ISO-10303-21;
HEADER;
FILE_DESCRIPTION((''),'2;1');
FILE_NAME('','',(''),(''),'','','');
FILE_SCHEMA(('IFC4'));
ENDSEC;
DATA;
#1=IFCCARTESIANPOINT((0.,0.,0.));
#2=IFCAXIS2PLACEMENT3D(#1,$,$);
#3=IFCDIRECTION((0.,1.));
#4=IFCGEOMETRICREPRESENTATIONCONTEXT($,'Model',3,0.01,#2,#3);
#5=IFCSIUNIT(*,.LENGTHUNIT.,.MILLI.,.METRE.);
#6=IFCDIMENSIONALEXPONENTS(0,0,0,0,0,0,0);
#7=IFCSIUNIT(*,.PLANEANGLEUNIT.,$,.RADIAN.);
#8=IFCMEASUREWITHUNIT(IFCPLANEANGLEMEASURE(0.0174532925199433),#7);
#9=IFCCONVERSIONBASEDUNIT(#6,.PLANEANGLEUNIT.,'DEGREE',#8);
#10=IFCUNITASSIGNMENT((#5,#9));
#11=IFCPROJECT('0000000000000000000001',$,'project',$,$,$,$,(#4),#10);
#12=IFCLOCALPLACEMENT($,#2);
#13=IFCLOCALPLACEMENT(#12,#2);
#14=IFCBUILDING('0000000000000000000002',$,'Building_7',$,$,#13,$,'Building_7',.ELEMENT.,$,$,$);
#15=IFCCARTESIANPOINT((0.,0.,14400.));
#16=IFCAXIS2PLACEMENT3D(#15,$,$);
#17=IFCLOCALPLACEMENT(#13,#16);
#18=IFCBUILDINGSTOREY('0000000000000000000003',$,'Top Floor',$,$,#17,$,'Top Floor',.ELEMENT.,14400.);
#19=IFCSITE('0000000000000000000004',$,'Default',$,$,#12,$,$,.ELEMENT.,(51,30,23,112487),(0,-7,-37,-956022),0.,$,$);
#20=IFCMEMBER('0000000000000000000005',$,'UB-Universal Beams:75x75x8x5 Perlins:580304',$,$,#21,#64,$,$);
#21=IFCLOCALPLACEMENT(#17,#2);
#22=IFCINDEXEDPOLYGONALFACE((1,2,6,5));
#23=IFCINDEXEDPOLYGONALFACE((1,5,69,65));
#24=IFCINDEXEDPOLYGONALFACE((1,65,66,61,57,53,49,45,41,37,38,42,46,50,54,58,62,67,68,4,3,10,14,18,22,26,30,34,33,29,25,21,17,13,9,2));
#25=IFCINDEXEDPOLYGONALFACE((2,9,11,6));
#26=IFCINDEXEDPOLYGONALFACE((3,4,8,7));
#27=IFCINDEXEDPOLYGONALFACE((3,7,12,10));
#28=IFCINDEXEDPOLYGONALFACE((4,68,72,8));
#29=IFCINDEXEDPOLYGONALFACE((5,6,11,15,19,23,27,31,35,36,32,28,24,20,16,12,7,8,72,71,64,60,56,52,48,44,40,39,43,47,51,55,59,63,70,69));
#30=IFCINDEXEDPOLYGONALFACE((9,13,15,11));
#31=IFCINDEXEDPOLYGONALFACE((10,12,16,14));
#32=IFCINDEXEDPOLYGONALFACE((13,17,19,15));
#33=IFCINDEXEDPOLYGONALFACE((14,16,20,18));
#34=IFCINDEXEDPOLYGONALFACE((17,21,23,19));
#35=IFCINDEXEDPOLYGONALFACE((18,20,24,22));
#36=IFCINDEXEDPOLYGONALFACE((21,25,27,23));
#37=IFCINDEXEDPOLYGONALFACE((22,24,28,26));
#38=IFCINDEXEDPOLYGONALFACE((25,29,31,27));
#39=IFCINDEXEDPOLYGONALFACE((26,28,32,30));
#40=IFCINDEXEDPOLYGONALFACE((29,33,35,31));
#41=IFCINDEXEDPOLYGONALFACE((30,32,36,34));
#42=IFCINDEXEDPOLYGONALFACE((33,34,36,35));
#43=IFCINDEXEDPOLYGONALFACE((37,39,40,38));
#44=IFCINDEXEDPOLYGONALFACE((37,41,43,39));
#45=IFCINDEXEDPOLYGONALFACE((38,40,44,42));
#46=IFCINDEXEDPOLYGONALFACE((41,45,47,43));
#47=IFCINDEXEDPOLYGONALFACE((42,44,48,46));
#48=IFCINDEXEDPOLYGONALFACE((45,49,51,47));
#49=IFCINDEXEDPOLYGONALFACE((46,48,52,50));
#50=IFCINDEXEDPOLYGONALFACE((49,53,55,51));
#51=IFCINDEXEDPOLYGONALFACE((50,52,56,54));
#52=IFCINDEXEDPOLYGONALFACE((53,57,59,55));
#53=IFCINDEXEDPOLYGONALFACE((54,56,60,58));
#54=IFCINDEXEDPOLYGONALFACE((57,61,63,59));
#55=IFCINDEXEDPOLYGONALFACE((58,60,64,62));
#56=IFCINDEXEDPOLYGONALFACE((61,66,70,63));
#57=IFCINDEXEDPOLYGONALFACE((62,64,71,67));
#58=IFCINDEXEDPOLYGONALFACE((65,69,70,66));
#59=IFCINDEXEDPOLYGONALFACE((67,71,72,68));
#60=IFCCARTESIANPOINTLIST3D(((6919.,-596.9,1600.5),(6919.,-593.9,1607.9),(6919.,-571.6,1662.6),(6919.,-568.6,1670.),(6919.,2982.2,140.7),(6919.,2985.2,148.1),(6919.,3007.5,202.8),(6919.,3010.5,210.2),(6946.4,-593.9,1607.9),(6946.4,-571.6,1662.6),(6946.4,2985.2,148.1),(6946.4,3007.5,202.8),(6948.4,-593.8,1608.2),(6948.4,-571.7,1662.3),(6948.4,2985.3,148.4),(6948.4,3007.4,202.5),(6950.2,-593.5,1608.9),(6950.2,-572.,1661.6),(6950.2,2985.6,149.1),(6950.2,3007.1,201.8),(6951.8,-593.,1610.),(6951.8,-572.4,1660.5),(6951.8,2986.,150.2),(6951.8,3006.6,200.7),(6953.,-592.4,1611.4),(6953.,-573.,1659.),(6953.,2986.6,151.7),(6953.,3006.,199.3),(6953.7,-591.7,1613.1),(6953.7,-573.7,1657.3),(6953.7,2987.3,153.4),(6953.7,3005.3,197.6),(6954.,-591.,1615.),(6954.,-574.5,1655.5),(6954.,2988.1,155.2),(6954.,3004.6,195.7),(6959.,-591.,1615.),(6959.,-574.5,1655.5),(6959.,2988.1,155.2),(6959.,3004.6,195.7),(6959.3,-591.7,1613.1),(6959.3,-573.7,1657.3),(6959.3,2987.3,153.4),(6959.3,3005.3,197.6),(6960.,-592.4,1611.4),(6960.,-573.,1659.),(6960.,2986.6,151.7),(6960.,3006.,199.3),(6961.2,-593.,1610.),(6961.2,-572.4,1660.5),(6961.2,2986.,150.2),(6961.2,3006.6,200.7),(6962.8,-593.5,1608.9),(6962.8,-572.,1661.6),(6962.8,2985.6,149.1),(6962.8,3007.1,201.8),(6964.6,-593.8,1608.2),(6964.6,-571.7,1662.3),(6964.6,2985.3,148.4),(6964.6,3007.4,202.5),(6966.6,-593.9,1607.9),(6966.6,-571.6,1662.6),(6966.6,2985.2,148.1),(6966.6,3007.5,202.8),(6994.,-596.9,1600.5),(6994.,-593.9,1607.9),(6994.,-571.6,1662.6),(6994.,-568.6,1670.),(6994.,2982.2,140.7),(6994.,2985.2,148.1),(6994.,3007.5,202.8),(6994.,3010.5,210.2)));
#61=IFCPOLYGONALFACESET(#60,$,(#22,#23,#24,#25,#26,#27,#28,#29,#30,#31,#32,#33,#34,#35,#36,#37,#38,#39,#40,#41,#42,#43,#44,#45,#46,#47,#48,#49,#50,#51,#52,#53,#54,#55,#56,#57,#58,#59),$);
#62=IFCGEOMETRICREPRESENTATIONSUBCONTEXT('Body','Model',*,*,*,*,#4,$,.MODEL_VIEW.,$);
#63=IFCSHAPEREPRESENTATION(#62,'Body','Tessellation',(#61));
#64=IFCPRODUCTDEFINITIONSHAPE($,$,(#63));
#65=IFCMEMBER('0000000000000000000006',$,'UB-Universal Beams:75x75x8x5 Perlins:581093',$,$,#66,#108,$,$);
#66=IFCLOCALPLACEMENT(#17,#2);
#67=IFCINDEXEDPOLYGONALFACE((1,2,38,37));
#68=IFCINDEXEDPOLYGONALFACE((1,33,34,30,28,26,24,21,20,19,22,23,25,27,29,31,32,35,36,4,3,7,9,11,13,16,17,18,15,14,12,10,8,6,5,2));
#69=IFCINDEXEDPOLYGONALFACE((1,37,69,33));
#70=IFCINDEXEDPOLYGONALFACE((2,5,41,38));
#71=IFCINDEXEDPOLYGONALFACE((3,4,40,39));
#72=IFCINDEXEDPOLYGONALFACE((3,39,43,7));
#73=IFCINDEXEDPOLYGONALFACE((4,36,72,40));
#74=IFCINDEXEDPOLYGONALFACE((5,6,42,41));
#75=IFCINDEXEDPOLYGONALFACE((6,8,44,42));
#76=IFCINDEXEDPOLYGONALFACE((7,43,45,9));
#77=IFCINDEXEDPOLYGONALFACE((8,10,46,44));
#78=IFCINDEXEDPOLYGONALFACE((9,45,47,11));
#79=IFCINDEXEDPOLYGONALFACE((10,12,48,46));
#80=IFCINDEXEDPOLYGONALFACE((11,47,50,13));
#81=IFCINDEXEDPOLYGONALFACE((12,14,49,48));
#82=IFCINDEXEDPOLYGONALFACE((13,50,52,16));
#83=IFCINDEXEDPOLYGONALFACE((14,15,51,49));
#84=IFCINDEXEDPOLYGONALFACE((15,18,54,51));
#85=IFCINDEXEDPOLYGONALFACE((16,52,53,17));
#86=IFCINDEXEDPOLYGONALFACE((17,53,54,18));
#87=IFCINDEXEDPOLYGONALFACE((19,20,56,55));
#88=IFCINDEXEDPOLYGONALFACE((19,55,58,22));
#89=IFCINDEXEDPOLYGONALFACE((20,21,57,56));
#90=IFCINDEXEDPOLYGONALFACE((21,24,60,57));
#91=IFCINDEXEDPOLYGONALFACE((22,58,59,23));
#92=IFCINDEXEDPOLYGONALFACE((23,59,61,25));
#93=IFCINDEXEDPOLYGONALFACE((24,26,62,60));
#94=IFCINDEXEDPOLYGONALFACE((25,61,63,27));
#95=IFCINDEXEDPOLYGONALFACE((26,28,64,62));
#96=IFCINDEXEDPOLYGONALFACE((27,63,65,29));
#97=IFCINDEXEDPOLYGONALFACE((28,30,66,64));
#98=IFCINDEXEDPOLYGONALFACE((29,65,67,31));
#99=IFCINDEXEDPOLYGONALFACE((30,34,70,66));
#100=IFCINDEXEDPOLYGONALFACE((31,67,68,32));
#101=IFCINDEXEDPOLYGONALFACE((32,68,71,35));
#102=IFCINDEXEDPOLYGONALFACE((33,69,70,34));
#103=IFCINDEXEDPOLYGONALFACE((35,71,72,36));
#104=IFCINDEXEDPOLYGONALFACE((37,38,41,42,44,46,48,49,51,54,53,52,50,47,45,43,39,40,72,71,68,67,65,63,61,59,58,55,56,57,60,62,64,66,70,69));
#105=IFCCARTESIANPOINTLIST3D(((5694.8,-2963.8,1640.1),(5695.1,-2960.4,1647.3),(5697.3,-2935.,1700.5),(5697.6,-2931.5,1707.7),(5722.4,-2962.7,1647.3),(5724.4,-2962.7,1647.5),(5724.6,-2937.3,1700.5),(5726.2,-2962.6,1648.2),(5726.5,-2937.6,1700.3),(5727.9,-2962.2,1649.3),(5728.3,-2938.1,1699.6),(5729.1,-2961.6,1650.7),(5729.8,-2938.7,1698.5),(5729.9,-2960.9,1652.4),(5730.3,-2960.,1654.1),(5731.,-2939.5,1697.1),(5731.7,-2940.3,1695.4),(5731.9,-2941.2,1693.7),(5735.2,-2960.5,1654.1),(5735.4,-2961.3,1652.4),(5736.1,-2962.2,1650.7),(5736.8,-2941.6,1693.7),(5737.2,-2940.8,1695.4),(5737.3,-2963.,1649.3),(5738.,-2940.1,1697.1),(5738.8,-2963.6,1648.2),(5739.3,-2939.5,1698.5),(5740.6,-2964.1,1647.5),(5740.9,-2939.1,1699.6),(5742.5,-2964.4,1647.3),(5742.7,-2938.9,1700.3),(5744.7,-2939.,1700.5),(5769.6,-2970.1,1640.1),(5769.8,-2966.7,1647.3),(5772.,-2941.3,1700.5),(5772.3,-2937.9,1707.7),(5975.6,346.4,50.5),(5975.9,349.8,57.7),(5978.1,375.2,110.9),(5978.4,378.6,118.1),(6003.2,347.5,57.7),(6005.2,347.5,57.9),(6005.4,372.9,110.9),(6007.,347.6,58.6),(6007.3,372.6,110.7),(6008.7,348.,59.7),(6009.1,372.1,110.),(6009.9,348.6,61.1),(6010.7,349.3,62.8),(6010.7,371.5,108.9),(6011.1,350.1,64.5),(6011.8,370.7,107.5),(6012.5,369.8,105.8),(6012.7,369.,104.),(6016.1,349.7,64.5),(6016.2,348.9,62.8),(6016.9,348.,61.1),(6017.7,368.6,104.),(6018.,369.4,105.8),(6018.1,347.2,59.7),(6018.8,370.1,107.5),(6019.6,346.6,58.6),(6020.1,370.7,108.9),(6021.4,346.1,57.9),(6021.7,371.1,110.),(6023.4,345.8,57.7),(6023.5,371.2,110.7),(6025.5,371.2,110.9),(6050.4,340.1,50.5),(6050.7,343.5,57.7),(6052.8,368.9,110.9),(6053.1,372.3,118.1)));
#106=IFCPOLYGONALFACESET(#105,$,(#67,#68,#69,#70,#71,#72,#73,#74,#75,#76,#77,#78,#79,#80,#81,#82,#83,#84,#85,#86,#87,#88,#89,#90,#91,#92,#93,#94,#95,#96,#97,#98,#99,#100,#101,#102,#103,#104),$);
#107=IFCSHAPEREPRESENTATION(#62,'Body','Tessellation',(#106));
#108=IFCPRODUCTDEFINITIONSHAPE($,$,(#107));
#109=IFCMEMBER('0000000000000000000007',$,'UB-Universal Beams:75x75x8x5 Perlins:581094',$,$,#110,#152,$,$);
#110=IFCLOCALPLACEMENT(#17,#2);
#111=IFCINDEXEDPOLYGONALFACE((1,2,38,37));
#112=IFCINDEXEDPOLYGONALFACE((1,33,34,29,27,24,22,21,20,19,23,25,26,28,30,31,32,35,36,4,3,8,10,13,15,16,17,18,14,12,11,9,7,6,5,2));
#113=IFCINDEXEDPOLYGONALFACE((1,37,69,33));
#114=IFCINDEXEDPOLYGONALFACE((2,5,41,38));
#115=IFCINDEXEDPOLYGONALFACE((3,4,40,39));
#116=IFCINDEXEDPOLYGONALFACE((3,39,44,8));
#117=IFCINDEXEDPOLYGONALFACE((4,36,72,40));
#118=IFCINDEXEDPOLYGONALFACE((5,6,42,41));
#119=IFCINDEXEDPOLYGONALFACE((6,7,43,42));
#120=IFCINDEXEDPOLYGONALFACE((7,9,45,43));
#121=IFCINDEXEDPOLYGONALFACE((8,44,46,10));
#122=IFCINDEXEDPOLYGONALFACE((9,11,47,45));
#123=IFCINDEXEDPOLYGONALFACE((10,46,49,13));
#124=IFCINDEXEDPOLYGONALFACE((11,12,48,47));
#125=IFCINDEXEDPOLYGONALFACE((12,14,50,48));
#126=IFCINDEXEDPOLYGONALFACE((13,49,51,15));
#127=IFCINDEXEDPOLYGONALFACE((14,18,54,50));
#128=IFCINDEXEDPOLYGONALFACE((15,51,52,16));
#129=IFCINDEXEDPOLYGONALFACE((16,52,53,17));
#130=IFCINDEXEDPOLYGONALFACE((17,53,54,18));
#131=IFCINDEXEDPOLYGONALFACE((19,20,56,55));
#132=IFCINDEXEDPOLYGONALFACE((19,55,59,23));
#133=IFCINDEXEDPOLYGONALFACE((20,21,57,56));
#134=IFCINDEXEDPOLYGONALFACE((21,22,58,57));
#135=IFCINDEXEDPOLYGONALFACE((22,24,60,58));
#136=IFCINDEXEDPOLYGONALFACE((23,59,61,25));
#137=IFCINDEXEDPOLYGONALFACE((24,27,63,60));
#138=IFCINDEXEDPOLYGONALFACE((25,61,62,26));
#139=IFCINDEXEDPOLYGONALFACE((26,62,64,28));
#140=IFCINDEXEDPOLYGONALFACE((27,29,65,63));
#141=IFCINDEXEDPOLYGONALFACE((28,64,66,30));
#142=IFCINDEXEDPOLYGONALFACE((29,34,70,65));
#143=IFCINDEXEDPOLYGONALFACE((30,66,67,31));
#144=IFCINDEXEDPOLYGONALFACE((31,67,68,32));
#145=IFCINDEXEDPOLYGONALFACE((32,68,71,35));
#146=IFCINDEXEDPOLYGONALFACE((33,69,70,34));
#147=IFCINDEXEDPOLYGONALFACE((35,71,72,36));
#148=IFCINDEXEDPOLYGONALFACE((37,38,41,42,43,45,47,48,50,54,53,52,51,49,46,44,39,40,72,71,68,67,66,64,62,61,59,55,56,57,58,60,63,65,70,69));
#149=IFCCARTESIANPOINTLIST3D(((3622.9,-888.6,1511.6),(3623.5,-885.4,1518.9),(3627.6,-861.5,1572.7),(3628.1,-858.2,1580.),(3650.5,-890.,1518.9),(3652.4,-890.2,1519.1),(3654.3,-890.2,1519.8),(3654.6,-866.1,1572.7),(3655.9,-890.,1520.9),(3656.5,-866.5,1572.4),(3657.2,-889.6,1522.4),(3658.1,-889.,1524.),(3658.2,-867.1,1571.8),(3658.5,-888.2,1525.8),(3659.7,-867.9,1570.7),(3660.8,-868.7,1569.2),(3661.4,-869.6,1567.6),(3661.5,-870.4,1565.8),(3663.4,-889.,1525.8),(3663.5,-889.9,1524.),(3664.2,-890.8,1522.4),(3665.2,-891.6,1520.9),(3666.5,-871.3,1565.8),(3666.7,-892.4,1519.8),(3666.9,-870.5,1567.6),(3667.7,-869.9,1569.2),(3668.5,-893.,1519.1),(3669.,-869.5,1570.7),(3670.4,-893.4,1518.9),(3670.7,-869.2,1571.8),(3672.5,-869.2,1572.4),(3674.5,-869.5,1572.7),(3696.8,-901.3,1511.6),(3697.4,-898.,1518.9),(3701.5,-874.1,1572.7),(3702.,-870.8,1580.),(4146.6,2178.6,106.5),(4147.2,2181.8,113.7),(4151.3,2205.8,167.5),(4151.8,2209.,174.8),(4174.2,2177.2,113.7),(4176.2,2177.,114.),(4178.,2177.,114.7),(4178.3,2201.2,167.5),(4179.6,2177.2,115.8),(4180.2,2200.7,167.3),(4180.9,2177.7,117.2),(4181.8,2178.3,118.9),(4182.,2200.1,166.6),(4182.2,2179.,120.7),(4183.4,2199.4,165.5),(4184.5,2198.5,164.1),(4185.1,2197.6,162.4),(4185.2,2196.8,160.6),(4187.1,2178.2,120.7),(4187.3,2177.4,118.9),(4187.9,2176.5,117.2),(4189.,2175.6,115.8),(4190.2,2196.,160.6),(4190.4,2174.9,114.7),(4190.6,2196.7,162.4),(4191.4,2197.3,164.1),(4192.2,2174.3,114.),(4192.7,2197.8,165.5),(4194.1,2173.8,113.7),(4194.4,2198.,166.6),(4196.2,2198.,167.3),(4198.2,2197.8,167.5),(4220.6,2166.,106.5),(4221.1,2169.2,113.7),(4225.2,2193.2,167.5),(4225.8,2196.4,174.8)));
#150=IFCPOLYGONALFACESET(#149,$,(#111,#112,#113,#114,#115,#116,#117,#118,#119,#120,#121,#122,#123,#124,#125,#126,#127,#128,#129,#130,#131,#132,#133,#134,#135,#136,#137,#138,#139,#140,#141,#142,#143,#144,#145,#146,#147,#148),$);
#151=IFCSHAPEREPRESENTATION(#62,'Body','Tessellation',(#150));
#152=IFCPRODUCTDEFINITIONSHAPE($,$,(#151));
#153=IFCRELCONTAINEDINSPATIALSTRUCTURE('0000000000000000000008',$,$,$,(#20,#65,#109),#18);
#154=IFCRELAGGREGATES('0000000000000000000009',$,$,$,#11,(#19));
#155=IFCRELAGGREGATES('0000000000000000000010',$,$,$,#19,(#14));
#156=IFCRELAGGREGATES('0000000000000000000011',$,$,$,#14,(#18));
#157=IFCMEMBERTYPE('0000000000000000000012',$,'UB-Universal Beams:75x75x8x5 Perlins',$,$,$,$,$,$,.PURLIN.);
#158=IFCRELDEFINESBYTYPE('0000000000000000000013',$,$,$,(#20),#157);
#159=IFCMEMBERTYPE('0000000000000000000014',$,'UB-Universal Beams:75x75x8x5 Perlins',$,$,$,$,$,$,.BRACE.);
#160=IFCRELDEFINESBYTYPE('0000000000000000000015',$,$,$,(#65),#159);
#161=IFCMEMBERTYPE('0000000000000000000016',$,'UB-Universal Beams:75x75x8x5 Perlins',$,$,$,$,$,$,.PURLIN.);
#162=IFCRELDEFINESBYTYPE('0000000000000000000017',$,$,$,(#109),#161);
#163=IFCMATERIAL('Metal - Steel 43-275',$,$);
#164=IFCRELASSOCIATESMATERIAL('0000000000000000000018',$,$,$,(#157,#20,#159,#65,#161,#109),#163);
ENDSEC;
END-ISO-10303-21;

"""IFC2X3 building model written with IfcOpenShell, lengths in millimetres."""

from ifc_helpers import new_model, entity, si_unit, converted_unit, direction, frame, frame_2d, origin, place, context, subcontext, project, spatial, polyline, circle_curve, parameter, trimmed, segment, composite_curve, outline, extrude, source, transform, mapped, material, type_object, type_shapes, element, save


model = new_model("IFC2X3")

# Units and contexts
model_context = context("Model", 3, precision=0.01, world=origin(), true_north=direction((0.0, 1.0)))
body_context = subcontext(model_context, "Body", "Model", "MODEL_VIEW")
ifc_project = project(units=[si_unit("LENGTHUNIT", "METRE", prefix="MILLI"), converted_unit("PLANEANGLEUNIT", "DEGREE", entity("IfcPlaneAngleMeasure", 0.0174532925199433), si_unit("PLANEANGLEUNIT", "RADIAN"), dimensions=[0, 0, 0, 0, 0, 0, 0])], contexts=[model_context])

# Site, building, storey
site_placement = place(None, origin())
site = spatial("IfcSite", under=ifc_project, at=site_placement, Name="Default", CompositionType="ELEMENT", RefLatitude=(51, 30, 23, 112487), RefLongitude=(0, -7, -37, -956022), RefElevation=0.0)
building_placement = place(site_placement, origin())
building = spatial("IfcBuilding", under=site, at=building_placement, Name="Building_7", LongName="Building_7", CompositionType="ELEMENT")
storey_placement = place(building_placement, frame((0.0, 0.0, 14400.0)))
storey = spatial("IfcBuildingStorey", under=building, at=storey_placement, Name="Top Floor", LongName="Top Floor", CompositionType="ELEMENT", Elevation=14400.0)

# Shared definitions
ifc_material = material(Name="Metal - Steel 43-275")

# Members
member_type_1 = type_object("IfcMemberType", Name="UB-Universal Beams:75x75x8x5 Perlins", PredefinedType="PURLIN", material=ifc_material)
shared_shape_1 = source(origin(), body_context, "Body", "SweptSolid", [
    extrude(outline(composite_curve([segment(polyline([(29.5, -37.5), (37.5, -37.5)]), True, "CONTINUOUS"), segment(polyline([(37.5, -37.5), (37.5, 37.5)]), True, "CONTINUOUS"), segment(polyline([(37.5, 37.5), (29.5, 37.5)]), True, "CONTINUOUS"), segment(polyline([(29.5, 37.5), (29.5, 10.1)]), True, "CONTINUOUS"), segment(trimmed(circle_curve(frame_2d((21.9, 10.1), x_axis=(0.0, 1.0)), 7.6), [parameter(180.0)], [parameter(270.0)], True, "PARAMETER"), False, "CONTINUOUS"), segment(polyline([(21.9, 2.5), (-21.9, 2.5)]), True, "CONTINUOUS"), segment(trimmed(circle_curve(frame_2d((-21.9, 10.1), x_axis=(0.0, 1.0)), 7.6), [parameter(90.0)], [parameter(180.0)], True, "PARAMETER"), False, "CONTINUOUS"), segment(polyline([(-29.5, 10.1), (-29.5, 37.5)]), True, "CONTINUOUS"), segment(polyline([(-29.5, 37.5), (-37.5, 37.5)]), True, "CONTINUOUS"), segment(polyline([(-37.5, 37.5), (-37.5, -37.5)]), True, "CONTINUOUS"), segment(polyline([(-37.5, -37.5), (-29.5, -37.5)]), True, "CONTINUOUS"), segment(polyline([(-29.5, -37.5), (-29.5, -10.1)]), True, "CONTINUOUS"), segment(trimmed(circle_curve(frame_2d((-21.9, -10.1), x_axis=(0.0, 1.0)), 7.6), [parameter(360.0)], [parameter(90.0)], True, "PARAMETER"), False, "CONTINUOUS"), segment(polyline([(-21.9, -2.5), (21.9, -2.5)]), True, "CONTINUOUS"), segment(trimmed(circle_curve(frame_2d((21.9, -10.1), x_axis=(0.0, 1.0)), 7.6), [parameter(270.0)], [parameter(360.0)], True, "PARAMETER"), False, "CONTINUOUS"), segment(polyline([(29.5, -10.1), (29.5, -37.5)]), True, "CONTINUOUS")], self_intersect=False)), frame((-1965.2, 0.0, 0.0), z_axis=(1.0, 0.0, 0.0), x_axis=(0.0, 0.0, -1.0)), (0.0, 0.0, 1.0), 3865.3),
])
type_shapes(member_type_1, [shared_shape_1])
member_1_placement = place(storey_placement, frame((6956.5, 1176.7, 917.6), z_axis=(0.0, 0.377661, 0.925944), x_axis=(0.0, -0.925944, 0.377661)))
element("IfcMember", 1, at=member_1_placement, inside=storey, type_object=member_type_1, material=ifc_material, Name="UB-Universal Beams:75x75x8x5 Perlins:580304", context=body_context, shape_type="MappedRepresentation", body=[
    mapped(shared_shape_1, transform((0.0, 0.0, 0.0), scale=1.0)),
])
member_type_2 = type_object("IfcMemberType", Name="UB-Universal Beams:75x75x8x5 Perlins", PredefinedType="BRACE", material=ifc_material)
shared_shape_2 = source(origin(), body_context, "Body", "SweptSolid", [
    extrude(outline(composite_curve([segment(polyline([(29.5, -37.5), (37.5, -37.5)]), True, "CONTINUOUS"), segment(polyline([(37.5, -37.5), (37.5, 37.5)]), True, "CONTINUOUS"), segment(polyline([(37.5, 37.5), (29.5, 37.5)]), True, "CONTINUOUS"), segment(polyline([(29.5, 37.5), (29.5, 10.1)]), True, "CONTINUOUS"), segment(trimmed(circle_curve(frame_2d((21.9, 10.1), x_axis=(0.0, 1.0)), 7.6), [parameter(180.0)], [parameter(270.0)], True, "PARAMETER"), False, "CONTINUOUS"), segment(polyline([(21.9, 2.5), (-21.9, 2.5)]), True, "CONTINUOUS"), segment(trimmed(circle_curve(frame_2d((-21.9, 10.1), x_axis=(0.0, 1.0)), 7.6), [parameter(90.0)], [parameter(180.0)], True, "PARAMETER"), False, "CONTINUOUS"), segment(polyline([(-29.5, 10.1), (-29.5, 37.5)]), True, "CONTINUOUS"), segment(polyline([(-29.5, 37.5), (-37.5, 37.5)]), True, "CONTINUOUS"), segment(polyline([(-37.5, 37.5), (-37.5, -37.5)]), True, "CONTINUOUS"), segment(polyline([(-37.5, -37.5), (-29.5, -37.5)]), True, "CONTINUOUS"), segment(polyline([(-29.5, -37.5), (-29.5, -10.1)]), True, "CONTINUOUS"), segment(trimmed(circle_curve(frame_2d((-21.9, -10.1), x_axis=(0.0, 1.0)), 7.6), [parameter(360.0)], [parameter(90.0)], True, "PARAMETER"), False, "CONTINUOUS"), segment(polyline([(-21.9, -2.5), (21.9, -2.5)]), True, "CONTINUOUS"), segment(trimmed(circle_curve(frame_2d((21.9, -10.1), x_axis=(0.0, 1.0)), 7.6), [parameter(270.0)], [parameter(360.0)], True, "PARAMETER"), False, "CONTINUOUS"), segment(polyline([(29.5, -10.1), (29.5, -37.5)]), True, "CONTINUOUS")], self_intersect=False)), frame((-1841.4, 0.0, 0.0), z_axis=(1.0, 0.0, 0.0), x_axis=(0.0, 0.0, -1.0)), (0.0, 0.0, 1.0), 3682.8),
])
type_shapes(member_type_2, [shared_shape_2])
member_2_placement = place(storey_placement, frame((5874.0, -1295.7, 879.1), z_axis=(0.036485, 0.430084, 0.902052), x_axis=(-0.076249, -0.898823, 0.431628)))
element("IfcMember", 2, at=member_2_placement, inside=storey, type_object=member_type_2, material=ifc_material, Name="UB-Universal Beams:75x75x8x5 Perlins:581093", context=body_context, shape_type="MappedRepresentation", body=[
    mapped(shared_shape_2, transform((0.0, 0.0, 0.0), scale=1.0)),
])
member_type_3 = type_object("IfcMemberType", Name="UB-Universal Beams:75x75x8x5 Perlins", PredefinedType="PURLIN", material=ifc_material)
shared_shape_3 = source(origin(), body_context, "Body", "SweptSolid", [
    extrude(outline(composite_curve([segment(polyline([(29.5, -37.5), (37.5, -37.5)]), True, "CONTINUOUS"), segment(polyline([(37.5, -37.5), (37.5, 37.5)]), True, "CONTINUOUS"), segment(polyline([(37.5, 37.5), (29.5, 37.5)]), True, "CONTINUOUS"), segment(polyline([(29.5, 37.5), (29.5, 10.1)]), True, "CONTINUOUS"), segment(trimmed(circle_curve(frame_2d((21.9, 10.1), x_axis=(0.0, 1.0)), 7.6), [parameter(180.0)], [parameter(270.0)], True, "PARAMETER"), False, "CONTINUOUS"), segment(polyline([(21.9, 2.5), (-21.9, 2.5)]), True, "CONTINUOUS"), segment(trimmed(circle_curve(frame_2d((-21.9, 10.1), x_axis=(0.0, 1.0)), 7.6), [parameter(90.0)], [parameter(180.0)], True, "PARAMETER"), False, "CONTINUOUS"), segment(polyline([(-29.5, 10.1), (-29.5, 37.5)]), True, "CONTINUOUS"), segment(polyline([(-29.5, 37.5), (-37.5, 37.5)]), True, "CONTINUOUS"), segment(polyline([(-37.5, 37.5), (-37.5, -37.5)]), True, "CONTINUOUS"), segment(polyline([(-37.5, -37.5), (-29.5, -37.5)]), True, "CONTINUOUS"), segment(polyline([(-29.5, -37.5), (-29.5, -10.1)]), True, "CONTINUOUS"), segment(trimmed(circle_curve(frame_2d((-21.9, -10.1), x_axis=(0.0, 1.0)), 7.6), [parameter(360.0)], [parameter(90.0)], True, "PARAMETER"), False, "CONTINUOUS"), segment(polyline([(-21.9, -2.5), (21.9, -2.5)]), True, "CONTINUOUS"), segment(trimmed(circle_curve(frame_2d((21.9, -10.1), x_axis=(0.0, 1.0)), 7.6), [parameter(270.0)], [parameter(360.0)], True, "PARAMETER"), False, "CONTINUOUS"), segment(polyline([(29.5, -10.1), (29.5, -37.5)]), True, "CONTINUOUS")], self_intersect=False)), frame((-1707.1, 0.0, 0.0), z_axis=(1.0, 0.0, 0.0), x_axis=(0.0, 0.0, -1.0)), (0.0, 0.0, 1.0), 3414.2),
])
type_shapes(member_type_3, [shared_shape_3])
member_3_placement = place(storey_placement, frame((3924.3, 653.9, 843.2), z_axis=(0.06927, 0.405695, 0.91138), x_axis=(-0.153393, -0.898378, 0.411566)))
element("IfcMember", 3, at=member_3_placement, inside=storey, type_object=member_type_3, material=ifc_material, Name="UB-Universal Beams:75x75x8x5 Perlins:581094", context=body_context, shape_type="MappedRepresentation", body=[
    mapped(shared_shape_3, transform((0.0, 0.0, 0.0), scale=1.0)),
])

save(model, "model.ifc")
